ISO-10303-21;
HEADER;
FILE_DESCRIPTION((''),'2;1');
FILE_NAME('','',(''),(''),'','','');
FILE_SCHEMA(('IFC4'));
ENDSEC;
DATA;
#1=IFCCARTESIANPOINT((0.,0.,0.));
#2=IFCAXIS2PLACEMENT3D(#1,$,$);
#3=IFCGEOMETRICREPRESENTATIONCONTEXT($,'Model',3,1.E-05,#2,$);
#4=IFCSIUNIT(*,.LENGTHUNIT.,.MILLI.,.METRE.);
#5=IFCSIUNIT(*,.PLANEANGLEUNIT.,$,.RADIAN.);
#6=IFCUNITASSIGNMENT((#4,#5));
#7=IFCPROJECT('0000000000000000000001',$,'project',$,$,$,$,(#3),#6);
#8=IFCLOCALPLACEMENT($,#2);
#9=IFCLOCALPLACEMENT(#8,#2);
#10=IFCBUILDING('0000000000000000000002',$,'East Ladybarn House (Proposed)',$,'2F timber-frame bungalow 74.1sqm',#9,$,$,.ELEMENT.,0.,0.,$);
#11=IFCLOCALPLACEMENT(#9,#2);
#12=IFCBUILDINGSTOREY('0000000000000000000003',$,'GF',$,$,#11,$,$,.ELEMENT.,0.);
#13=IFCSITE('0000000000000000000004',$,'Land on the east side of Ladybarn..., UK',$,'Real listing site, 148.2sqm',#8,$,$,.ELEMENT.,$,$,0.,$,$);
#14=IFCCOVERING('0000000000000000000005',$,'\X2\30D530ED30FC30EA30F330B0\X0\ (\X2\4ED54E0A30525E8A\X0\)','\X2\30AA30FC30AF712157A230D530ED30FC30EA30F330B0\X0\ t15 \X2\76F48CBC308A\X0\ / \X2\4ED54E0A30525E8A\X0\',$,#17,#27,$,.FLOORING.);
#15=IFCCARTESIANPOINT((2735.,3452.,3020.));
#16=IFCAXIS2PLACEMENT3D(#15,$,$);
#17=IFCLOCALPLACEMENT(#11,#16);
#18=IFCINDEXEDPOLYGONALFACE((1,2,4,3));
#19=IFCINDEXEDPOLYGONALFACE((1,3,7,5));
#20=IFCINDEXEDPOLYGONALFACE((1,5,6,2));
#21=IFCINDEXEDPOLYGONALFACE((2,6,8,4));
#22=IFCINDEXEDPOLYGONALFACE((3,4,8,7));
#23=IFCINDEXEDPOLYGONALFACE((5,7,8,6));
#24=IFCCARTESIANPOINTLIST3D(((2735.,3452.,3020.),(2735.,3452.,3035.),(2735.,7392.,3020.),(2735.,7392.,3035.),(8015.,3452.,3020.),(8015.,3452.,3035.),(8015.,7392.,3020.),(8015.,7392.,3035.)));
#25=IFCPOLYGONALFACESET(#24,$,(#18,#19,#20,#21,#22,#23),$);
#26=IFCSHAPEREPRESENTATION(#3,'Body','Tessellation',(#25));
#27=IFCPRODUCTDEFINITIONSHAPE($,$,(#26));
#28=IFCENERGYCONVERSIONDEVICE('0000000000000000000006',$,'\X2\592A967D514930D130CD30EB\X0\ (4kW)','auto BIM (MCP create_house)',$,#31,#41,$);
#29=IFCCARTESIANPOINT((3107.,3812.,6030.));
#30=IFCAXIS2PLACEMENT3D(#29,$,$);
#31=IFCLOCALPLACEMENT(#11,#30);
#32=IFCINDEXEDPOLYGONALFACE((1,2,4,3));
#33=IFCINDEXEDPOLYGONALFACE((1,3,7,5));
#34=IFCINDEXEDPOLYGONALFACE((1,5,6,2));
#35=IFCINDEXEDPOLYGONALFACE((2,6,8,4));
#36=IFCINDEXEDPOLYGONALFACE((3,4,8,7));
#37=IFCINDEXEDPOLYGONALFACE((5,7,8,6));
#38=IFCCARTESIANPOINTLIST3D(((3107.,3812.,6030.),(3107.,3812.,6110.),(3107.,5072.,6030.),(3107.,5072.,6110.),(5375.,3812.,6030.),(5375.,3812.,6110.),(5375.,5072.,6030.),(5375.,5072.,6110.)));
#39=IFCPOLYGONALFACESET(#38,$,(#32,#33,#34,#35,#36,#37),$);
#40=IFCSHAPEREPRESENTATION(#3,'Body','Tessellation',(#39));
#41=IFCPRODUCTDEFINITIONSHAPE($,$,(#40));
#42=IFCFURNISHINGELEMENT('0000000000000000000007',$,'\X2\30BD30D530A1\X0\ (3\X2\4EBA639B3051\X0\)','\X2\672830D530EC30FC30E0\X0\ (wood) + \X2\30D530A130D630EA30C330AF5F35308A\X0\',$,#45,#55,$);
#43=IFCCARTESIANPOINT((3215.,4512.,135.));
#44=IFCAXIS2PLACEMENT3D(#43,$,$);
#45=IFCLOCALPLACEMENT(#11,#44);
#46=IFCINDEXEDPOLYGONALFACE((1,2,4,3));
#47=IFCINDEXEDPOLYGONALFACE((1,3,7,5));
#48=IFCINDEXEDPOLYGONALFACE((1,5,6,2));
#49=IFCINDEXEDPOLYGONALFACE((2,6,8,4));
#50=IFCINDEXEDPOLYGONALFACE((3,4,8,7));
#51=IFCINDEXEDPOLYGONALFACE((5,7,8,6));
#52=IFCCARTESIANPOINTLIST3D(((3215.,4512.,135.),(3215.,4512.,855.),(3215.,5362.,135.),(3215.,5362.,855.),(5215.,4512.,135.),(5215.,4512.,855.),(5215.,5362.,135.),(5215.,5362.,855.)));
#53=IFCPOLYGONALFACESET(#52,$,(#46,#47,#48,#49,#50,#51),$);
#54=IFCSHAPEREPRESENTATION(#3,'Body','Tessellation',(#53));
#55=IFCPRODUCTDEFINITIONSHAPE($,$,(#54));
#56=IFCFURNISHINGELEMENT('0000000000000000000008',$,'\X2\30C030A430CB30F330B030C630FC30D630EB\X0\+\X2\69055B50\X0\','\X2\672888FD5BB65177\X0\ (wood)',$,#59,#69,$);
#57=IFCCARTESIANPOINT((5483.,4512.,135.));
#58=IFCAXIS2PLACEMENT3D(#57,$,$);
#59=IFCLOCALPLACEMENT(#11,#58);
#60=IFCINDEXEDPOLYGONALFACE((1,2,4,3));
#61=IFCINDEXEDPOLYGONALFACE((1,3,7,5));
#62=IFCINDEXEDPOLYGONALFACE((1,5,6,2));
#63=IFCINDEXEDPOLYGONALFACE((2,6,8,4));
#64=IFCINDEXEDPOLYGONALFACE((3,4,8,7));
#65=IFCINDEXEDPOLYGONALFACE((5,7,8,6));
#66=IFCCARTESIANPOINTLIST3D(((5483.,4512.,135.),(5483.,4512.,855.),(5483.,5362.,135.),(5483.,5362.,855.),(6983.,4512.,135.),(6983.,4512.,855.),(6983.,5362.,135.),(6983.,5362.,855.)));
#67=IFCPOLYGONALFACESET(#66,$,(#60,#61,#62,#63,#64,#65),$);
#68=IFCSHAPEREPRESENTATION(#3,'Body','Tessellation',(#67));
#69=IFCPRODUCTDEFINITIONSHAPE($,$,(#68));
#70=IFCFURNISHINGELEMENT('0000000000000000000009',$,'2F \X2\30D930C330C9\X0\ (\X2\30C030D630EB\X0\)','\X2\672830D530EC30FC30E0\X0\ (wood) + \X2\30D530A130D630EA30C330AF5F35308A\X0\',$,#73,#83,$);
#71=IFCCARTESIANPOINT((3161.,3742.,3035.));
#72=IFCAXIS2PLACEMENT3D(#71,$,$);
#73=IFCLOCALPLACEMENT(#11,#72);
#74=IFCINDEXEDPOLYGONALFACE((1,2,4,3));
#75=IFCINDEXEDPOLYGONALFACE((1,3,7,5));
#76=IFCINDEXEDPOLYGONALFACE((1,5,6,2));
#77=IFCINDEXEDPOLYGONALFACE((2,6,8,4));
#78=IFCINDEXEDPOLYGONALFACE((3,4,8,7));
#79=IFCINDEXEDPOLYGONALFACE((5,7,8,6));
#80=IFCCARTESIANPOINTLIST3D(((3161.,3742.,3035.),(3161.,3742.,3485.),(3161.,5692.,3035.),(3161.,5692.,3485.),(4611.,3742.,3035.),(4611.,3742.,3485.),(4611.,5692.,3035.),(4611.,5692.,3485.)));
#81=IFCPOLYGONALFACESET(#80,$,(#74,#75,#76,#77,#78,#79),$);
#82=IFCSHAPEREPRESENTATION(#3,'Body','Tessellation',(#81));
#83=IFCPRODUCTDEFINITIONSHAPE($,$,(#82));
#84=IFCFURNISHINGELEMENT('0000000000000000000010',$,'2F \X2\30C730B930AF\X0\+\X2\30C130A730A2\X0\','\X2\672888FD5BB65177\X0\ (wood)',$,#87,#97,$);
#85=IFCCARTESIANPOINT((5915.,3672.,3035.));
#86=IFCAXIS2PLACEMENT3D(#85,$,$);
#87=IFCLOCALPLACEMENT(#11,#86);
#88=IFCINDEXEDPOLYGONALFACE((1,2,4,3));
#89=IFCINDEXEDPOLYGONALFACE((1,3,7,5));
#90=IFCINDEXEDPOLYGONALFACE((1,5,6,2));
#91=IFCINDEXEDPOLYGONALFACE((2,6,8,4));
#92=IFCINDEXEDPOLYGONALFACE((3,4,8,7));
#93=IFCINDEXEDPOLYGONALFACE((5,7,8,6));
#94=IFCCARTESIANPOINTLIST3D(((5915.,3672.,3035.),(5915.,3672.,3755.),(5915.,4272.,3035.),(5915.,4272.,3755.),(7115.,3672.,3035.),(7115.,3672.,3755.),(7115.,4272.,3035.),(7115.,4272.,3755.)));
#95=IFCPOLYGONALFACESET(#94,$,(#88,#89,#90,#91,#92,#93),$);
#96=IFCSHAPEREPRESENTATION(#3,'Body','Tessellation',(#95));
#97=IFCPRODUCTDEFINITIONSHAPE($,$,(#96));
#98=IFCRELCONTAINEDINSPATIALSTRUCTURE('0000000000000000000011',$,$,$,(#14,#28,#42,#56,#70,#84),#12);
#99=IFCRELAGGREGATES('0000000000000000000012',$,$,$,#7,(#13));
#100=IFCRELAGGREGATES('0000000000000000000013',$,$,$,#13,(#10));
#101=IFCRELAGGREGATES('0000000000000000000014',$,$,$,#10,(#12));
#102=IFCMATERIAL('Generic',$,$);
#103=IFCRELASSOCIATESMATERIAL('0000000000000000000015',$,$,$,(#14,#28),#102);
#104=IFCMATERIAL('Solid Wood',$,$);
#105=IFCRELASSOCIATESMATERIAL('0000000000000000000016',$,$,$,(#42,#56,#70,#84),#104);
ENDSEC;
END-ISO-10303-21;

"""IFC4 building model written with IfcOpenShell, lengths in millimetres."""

from ifc_helpers import new_model, si_unit, frame, frame_2d, origin, place, context, project, spatial, rectangle, extrude, material, element, save


model = new_model("IFC4")

# Units and contexts
model_context = context("Model", 3, precision=1e-05, world=origin())
ifc_project = project(units=[si_unit("LENGTHUNIT", "METRE", prefix="MILLI"), si_unit("PLANEANGLEUNIT", "RADIAN")], contexts=[model_context])

# Site, building, storey
site_placement = place(None, origin())
site = spatial("IfcSite", under=ifc_project, at=site_placement, Name="Land on the east side of Ladybarn..., UK", ObjectType="Real listing site, 148.2sqm", CompositionType="ELEMENT", RefElevation=0.0)
building_placement = place(site_placement, origin())
building = spatial("IfcBuilding", under=site, at=building_placement, Name="East Ladybarn House (Proposed)", ObjectType="2F timber-frame bungalow 74.1sqm", CompositionType="ELEMENT", ElevationOfRefHeight=0.0, ElevationOfTerrain=0.0)
storey_placement = place(building_placement, origin())
storey = spatial("IfcBuildingStorey", under=building, at=storey_placement, Name="GF", CompositionType="ELEMENT", Elevation=0.0)

# Shared definitions
ifc_material_1 = material(Name="Solid Wood")

# Covering
ifc_material_2 = material(Name="Generic")
covering_placement = place(storey_placement, frame((2735.0, 3452.0, 3020.0)))
element("IfcCovering", 1, at=covering_placement, inside=storey, material=ifc_material_2, Name="フローリング (仕上げ床)", Description="オーク無垢フローリング t15 直貼り / 仕上げ床", PredefinedType="FLOORING", context=model_context, shape_type="SweptSolid", body=[
    extrude(rectangle(XDim=5280.0, YDim=3940.0, at=frame_2d((2640.0, 1970.0))), frame((2735.0, 3452.0, 3020.0)), (0.0, 0.0, 1.0), 15.0),
])

# Energy conversion device
energy_conversion_device_placement = place(storey_placement, frame((3107.0, 3812.0, 6030.0)))
element("IfcEnergyConversionDevice", 2, at=energy_conversion_device_placement, inside=storey, material=ifc_material_2, Name="太陽光パネル (4kW)", Description="auto BIM (MCP create_house)", context=model_context, shape_type="SweptSolid", body=[
    extrude(rectangle(XDim=2268.0, YDim=1260.0, at=frame_2d((1134.0, 630.0))), frame((3107.0, 3812.0, 6030.0)), (0.0, 0.0, 1.0), 80.0),
])

# Furnishing elements
furnishing_1_placement = place(storey_placement, frame((3215.0, 4512.0, 135.0)))
element("IfcFurnishingElement", 3, at=furnishing_1_placement, inside=storey, material=ifc_material_1, Name="ソファ (3人掛け)", Description="木フレーム (wood) + ファブリック張り", context=model_context, shape_type="SweptSolid", body=[
    extrude(rectangle(XDim=2000.0, YDim=850.0, at=frame_2d((1000.0, 425.0))), frame((3215.0, 4512.0, 135.0)), (0.0, 0.0, 1.0), 720.0),
])
furnishing_2_placement = place(storey_placement, frame((5483.0, 4512.0, 135.0)))
element("IfcFurnishingElement", 4, at=furnishing_2_placement, inside=storey, material=ifc_material_1, Name="ダイニングテーブル+椅子", Description="木製家具 (wood)", context=model_context, shape_type="SweptSolid", body=[
    extrude(rectangle(XDim=1500.0, YDim=850.0, at=frame_2d((750.0, 425.0))), frame((5483.0, 4512.0, 135.0)), (0.0, 0.0, 1.0), 720.0),
])
furnishing_3_placement = place(storey_placement, frame((3161.0, 3742.0, 3035.0)))
element("IfcFurnishingElement", 5, at=furnishing_3_placement, inside=storey, material=ifc_material_1, Name="2F ベッド (ダブル)", Description="木フレーム (wood) + ファブリック張り", context=model_context, shape_type="SweptSolid", body=[
    extrude(rectangle(XDim=1450.0, YDim=1950.0, at=frame_2d((725.0, 975.0))), frame((3161.0, 3742.0, 3035.0)), (0.0, 0.0, 1.0), 450.0),
])
furnishing_4_placement = place(storey_placement, frame((5915.0, 3672.0, 3035.0)))
element("IfcFurnishingElement", 6, at=furnishing_4_placement, inside=storey, material=ifc_material_1, Name="2F デスク+チェア", Description="木製家具 (wood)", context=model_context, shape_type="SweptSolid", body=[
    extrude(rectangle(XDim=1200.0, YDim=600.0, at=frame_2d((600.0, 300.0))), frame((5915.0, 3672.0, 3035.0)), (0.0, 0.0, 1.0), 720.0),
])

save(model, "model.ifc")
